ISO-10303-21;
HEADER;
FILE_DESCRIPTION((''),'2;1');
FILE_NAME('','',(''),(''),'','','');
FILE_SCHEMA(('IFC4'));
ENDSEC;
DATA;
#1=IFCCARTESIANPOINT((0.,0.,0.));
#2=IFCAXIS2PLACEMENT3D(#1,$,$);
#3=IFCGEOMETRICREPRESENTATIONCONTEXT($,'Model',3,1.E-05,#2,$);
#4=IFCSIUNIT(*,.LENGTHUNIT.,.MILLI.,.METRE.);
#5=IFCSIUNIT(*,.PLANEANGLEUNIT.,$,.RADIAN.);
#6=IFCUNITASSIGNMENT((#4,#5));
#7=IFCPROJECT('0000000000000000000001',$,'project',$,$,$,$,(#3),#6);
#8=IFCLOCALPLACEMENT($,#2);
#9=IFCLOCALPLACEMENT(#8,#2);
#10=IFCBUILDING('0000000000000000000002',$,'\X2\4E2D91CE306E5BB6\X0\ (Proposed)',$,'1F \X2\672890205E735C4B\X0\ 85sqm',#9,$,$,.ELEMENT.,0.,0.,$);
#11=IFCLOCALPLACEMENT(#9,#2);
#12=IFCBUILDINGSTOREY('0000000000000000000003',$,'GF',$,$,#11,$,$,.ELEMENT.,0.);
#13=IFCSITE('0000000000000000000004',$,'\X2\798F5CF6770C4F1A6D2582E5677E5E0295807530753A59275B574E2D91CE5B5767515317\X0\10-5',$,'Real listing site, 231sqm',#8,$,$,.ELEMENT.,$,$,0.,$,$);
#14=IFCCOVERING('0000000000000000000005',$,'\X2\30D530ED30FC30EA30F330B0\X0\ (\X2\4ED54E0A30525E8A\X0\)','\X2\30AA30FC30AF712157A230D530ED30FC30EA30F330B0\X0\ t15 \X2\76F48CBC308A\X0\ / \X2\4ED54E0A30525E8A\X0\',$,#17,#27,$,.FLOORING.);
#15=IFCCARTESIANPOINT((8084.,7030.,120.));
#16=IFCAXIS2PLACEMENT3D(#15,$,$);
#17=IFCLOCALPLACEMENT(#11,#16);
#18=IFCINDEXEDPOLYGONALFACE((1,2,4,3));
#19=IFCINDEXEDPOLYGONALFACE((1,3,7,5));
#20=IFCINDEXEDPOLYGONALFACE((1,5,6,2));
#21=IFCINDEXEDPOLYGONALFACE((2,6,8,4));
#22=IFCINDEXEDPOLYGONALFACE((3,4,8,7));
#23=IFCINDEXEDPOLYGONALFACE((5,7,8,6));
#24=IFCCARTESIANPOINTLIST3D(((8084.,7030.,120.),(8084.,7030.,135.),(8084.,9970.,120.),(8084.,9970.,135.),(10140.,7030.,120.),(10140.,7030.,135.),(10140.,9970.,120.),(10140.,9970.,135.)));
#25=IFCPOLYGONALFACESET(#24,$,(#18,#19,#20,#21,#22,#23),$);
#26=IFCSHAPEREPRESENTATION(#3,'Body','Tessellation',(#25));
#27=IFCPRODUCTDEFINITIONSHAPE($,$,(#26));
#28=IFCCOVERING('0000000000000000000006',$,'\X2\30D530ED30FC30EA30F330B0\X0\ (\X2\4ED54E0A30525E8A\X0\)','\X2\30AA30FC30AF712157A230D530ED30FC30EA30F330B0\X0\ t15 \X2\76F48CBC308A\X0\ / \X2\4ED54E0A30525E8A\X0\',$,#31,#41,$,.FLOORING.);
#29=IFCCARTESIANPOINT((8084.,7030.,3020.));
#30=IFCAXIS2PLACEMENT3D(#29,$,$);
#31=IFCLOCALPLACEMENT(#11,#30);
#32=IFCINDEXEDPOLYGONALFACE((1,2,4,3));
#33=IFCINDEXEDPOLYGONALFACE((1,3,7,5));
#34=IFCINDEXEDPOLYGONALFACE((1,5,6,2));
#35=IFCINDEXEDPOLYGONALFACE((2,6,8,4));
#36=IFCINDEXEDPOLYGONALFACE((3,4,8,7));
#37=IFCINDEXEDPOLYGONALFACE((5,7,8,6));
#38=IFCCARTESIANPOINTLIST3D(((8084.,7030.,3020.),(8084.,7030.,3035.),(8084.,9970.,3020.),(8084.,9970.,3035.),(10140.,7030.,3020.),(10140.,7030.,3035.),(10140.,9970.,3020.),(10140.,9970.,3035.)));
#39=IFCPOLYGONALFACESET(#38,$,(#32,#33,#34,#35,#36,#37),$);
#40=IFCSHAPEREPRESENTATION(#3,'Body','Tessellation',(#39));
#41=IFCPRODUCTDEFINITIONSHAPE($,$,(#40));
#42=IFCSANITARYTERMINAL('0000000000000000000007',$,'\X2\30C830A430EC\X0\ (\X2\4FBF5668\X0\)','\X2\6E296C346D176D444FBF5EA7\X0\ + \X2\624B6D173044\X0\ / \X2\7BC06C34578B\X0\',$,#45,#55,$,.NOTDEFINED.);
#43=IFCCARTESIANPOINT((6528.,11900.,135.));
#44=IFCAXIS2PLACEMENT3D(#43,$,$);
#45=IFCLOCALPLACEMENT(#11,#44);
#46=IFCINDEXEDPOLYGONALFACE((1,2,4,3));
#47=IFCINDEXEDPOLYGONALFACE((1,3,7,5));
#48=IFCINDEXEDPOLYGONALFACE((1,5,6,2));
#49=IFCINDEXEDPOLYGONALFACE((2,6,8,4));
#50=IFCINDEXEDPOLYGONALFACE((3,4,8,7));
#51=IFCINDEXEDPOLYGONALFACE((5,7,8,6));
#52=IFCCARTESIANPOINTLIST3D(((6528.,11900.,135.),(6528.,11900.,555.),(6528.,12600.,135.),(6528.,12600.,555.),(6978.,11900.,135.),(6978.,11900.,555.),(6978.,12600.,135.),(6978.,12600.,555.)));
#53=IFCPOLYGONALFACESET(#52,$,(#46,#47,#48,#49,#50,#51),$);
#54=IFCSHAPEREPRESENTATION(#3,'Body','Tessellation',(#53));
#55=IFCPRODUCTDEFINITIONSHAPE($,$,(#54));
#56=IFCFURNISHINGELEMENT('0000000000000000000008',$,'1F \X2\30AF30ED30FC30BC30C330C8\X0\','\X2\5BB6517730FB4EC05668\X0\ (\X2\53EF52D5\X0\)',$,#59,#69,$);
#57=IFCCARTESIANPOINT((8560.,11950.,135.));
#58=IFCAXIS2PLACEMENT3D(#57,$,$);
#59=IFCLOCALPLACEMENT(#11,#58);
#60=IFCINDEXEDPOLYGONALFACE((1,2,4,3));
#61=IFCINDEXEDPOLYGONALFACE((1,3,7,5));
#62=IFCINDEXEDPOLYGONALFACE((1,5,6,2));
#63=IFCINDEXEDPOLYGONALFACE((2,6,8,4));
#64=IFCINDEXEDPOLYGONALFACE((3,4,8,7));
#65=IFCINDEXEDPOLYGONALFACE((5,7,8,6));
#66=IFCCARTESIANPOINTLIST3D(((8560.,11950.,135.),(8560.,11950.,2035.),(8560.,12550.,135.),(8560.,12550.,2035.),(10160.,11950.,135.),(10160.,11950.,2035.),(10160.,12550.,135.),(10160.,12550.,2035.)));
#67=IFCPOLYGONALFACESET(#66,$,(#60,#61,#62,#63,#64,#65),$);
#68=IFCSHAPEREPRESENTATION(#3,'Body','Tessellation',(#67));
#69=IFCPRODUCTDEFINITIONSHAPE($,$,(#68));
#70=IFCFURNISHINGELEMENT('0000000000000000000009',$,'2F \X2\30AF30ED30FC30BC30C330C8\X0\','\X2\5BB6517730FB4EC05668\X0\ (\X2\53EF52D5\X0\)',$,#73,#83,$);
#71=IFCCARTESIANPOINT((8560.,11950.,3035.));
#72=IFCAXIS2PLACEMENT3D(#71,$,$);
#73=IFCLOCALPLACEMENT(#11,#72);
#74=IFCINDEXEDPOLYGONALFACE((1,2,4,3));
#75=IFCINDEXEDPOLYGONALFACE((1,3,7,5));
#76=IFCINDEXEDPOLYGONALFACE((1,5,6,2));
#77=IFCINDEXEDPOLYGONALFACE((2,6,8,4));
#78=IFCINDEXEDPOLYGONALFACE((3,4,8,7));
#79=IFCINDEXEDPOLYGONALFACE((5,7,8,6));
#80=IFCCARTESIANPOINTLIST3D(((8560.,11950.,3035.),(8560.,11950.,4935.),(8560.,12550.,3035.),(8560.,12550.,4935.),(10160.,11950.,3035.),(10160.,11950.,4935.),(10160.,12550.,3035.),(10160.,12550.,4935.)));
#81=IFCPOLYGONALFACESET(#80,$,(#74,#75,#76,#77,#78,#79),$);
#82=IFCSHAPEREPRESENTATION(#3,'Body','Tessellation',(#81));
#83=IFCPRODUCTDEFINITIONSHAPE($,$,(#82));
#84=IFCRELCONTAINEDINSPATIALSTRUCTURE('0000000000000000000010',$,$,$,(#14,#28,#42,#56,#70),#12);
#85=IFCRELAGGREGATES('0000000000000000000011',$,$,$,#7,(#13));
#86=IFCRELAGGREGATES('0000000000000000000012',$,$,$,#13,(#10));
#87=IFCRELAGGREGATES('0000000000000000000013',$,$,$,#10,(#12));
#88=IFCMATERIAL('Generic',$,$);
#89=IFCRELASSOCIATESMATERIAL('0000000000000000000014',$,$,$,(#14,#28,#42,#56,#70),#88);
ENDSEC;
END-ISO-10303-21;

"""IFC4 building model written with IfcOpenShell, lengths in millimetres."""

from ifc_helpers import new_model, si_unit, frame, frame_2d, origin, place, context, project, spatial, rectangle, extrude, material, element, save


model = new_model("IFC4")

# Units and contexts
model_context = context("Model", 3, precision=1e-05, world=origin())
ifc_project = project(units=[si_unit("LENGTHUNIT", "METRE", prefix="MILLI"), si_unit("PLANEANGLEUNIT", "RADIAN")], contexts=[model_context])

# Site, building, storey
site_placement = place(None, origin())
site = spatial("IfcSite", under=ifc_project, at=site_placement, Name="福島県会津若松市門田町大字中野字村北10-5", ObjectType="Real listing site, 231sqm", CompositionType="ELEMENT", RefElevation=0.0)
building_placement = place(site_placement, origin())
building = spatial("IfcBuilding", under=site, at=building_placement, Name="中野の家 (Proposed)", ObjectType="1F 木造平屋 85sqm", CompositionType="ELEMENT", ElevationOfRefHeight=0.0, ElevationOfTerrain=0.0)
storey_placement = place(building_placement, origin())
storey = spatial("IfcBuildingStorey", under=building, at=storey_placement, Name="GF", CompositionType="ELEMENT", Elevation=0.0)

# Shared definitions
ifc_material_1 = material(Name="Generic")

# Coverings
covering_1_placement = place(storey_placement, frame((8084.0, 7030.0, 120.0)))
element("IfcCovering", 1, at=covering_1_placement, inside=storey, material=ifc_material_1, Name="フローリング (仕上げ床)", Description="オーク無垢フローリング t15 直貼り / 仕上げ床", PredefinedType="FLOORING", context=model_context, shape_type="SweptSolid", body=[
    extrude(rectangle(XDim=2056.0, YDim=2940.0, at=frame_2d((1028.0, 1470.0))), frame((8084.0, 7030.0, 120.0)), (0.0, 0.0, 1.0), 15.0),
])
covering_2_placement = place(storey_placement, frame((8084.0, 7030.0, 3020.0)))
element("IfcCovering", 2, at=covering_2_placement, inside=storey, material=ifc_material_1, Name="フローリング (仕上げ床)", Description="オーク無垢フローリング t15 直貼り / 仕上げ床", PredefinedType="FLOORING", context=model_context, shape_type="SweptSolid", body=[
    extrude(rectangle(XDim=2056.0, YDim=2940.0, at=frame_2d((1028.0, 1470.0))), frame((8084.0, 7030.0, 3020.0)), (0.0, 0.0, 1.0), 15.0),
])

# Sanitary terminal
sanitary_terminal_placement = place(storey_placement, frame((6528.0, 11900.0, 135.0)))
element("IfcSanitaryTerminal", 3, at=sanitary_terminal_placement, inside=storey, material=ifc_material_1, Name="トイレ (便器)", Description="温水洗浄便座 + 手洗い / 節水型", PredefinedType="NOTDEFINED", context=model_context, shape_type="SweptSolid", body=[
    extrude(rectangle(XDim=450.0, YDim=700.0, at=frame_2d((225.0, 350.0))), frame((6528.0, 11900.0, 135.0)), (0.0, 0.0, 1.0), 420.0),
])

# Furnishing elements
furnishing_1_placement = place(storey_placement, frame((8560.0, 11950.0, 135.0)))
element("IfcFurnishingElement", 4, at=furnishing_1_placement, inside=storey, material=ifc_material_1, Name="1F クローゼット", Description="家具・什器 (可動)", context=model_context, shape_type="SweptSolid", body=[
    extrude(rectangle(XDim=1600.0, YDim=600.0, at=frame_2d((800.0, 300.0))), frame((8560.0, 11950.0, 135.0)), (0.0, 0.0, 1.0), 1900.0),
])
furnishing_2_placement = place(storey_placement, frame((8560.0, 11950.0, 3035.0)))
element("IfcFurnishingElement", 5, at=furnishing_2_placement, inside=storey, material=ifc_material_1, Name="2F クローゼット", Description="家具・什器 (可動)", context=model_context, shape_type="SweptSolid", body=[
    extrude(rectangle(XDim=1600.0, YDim=600.0, at=frame_2d((800.0, 300.0))), frame((8560.0, 11950.0, 3035.0)), (0.0, 0.0, 1.0), 1900.0),
])

save(model, "model.ifc")
